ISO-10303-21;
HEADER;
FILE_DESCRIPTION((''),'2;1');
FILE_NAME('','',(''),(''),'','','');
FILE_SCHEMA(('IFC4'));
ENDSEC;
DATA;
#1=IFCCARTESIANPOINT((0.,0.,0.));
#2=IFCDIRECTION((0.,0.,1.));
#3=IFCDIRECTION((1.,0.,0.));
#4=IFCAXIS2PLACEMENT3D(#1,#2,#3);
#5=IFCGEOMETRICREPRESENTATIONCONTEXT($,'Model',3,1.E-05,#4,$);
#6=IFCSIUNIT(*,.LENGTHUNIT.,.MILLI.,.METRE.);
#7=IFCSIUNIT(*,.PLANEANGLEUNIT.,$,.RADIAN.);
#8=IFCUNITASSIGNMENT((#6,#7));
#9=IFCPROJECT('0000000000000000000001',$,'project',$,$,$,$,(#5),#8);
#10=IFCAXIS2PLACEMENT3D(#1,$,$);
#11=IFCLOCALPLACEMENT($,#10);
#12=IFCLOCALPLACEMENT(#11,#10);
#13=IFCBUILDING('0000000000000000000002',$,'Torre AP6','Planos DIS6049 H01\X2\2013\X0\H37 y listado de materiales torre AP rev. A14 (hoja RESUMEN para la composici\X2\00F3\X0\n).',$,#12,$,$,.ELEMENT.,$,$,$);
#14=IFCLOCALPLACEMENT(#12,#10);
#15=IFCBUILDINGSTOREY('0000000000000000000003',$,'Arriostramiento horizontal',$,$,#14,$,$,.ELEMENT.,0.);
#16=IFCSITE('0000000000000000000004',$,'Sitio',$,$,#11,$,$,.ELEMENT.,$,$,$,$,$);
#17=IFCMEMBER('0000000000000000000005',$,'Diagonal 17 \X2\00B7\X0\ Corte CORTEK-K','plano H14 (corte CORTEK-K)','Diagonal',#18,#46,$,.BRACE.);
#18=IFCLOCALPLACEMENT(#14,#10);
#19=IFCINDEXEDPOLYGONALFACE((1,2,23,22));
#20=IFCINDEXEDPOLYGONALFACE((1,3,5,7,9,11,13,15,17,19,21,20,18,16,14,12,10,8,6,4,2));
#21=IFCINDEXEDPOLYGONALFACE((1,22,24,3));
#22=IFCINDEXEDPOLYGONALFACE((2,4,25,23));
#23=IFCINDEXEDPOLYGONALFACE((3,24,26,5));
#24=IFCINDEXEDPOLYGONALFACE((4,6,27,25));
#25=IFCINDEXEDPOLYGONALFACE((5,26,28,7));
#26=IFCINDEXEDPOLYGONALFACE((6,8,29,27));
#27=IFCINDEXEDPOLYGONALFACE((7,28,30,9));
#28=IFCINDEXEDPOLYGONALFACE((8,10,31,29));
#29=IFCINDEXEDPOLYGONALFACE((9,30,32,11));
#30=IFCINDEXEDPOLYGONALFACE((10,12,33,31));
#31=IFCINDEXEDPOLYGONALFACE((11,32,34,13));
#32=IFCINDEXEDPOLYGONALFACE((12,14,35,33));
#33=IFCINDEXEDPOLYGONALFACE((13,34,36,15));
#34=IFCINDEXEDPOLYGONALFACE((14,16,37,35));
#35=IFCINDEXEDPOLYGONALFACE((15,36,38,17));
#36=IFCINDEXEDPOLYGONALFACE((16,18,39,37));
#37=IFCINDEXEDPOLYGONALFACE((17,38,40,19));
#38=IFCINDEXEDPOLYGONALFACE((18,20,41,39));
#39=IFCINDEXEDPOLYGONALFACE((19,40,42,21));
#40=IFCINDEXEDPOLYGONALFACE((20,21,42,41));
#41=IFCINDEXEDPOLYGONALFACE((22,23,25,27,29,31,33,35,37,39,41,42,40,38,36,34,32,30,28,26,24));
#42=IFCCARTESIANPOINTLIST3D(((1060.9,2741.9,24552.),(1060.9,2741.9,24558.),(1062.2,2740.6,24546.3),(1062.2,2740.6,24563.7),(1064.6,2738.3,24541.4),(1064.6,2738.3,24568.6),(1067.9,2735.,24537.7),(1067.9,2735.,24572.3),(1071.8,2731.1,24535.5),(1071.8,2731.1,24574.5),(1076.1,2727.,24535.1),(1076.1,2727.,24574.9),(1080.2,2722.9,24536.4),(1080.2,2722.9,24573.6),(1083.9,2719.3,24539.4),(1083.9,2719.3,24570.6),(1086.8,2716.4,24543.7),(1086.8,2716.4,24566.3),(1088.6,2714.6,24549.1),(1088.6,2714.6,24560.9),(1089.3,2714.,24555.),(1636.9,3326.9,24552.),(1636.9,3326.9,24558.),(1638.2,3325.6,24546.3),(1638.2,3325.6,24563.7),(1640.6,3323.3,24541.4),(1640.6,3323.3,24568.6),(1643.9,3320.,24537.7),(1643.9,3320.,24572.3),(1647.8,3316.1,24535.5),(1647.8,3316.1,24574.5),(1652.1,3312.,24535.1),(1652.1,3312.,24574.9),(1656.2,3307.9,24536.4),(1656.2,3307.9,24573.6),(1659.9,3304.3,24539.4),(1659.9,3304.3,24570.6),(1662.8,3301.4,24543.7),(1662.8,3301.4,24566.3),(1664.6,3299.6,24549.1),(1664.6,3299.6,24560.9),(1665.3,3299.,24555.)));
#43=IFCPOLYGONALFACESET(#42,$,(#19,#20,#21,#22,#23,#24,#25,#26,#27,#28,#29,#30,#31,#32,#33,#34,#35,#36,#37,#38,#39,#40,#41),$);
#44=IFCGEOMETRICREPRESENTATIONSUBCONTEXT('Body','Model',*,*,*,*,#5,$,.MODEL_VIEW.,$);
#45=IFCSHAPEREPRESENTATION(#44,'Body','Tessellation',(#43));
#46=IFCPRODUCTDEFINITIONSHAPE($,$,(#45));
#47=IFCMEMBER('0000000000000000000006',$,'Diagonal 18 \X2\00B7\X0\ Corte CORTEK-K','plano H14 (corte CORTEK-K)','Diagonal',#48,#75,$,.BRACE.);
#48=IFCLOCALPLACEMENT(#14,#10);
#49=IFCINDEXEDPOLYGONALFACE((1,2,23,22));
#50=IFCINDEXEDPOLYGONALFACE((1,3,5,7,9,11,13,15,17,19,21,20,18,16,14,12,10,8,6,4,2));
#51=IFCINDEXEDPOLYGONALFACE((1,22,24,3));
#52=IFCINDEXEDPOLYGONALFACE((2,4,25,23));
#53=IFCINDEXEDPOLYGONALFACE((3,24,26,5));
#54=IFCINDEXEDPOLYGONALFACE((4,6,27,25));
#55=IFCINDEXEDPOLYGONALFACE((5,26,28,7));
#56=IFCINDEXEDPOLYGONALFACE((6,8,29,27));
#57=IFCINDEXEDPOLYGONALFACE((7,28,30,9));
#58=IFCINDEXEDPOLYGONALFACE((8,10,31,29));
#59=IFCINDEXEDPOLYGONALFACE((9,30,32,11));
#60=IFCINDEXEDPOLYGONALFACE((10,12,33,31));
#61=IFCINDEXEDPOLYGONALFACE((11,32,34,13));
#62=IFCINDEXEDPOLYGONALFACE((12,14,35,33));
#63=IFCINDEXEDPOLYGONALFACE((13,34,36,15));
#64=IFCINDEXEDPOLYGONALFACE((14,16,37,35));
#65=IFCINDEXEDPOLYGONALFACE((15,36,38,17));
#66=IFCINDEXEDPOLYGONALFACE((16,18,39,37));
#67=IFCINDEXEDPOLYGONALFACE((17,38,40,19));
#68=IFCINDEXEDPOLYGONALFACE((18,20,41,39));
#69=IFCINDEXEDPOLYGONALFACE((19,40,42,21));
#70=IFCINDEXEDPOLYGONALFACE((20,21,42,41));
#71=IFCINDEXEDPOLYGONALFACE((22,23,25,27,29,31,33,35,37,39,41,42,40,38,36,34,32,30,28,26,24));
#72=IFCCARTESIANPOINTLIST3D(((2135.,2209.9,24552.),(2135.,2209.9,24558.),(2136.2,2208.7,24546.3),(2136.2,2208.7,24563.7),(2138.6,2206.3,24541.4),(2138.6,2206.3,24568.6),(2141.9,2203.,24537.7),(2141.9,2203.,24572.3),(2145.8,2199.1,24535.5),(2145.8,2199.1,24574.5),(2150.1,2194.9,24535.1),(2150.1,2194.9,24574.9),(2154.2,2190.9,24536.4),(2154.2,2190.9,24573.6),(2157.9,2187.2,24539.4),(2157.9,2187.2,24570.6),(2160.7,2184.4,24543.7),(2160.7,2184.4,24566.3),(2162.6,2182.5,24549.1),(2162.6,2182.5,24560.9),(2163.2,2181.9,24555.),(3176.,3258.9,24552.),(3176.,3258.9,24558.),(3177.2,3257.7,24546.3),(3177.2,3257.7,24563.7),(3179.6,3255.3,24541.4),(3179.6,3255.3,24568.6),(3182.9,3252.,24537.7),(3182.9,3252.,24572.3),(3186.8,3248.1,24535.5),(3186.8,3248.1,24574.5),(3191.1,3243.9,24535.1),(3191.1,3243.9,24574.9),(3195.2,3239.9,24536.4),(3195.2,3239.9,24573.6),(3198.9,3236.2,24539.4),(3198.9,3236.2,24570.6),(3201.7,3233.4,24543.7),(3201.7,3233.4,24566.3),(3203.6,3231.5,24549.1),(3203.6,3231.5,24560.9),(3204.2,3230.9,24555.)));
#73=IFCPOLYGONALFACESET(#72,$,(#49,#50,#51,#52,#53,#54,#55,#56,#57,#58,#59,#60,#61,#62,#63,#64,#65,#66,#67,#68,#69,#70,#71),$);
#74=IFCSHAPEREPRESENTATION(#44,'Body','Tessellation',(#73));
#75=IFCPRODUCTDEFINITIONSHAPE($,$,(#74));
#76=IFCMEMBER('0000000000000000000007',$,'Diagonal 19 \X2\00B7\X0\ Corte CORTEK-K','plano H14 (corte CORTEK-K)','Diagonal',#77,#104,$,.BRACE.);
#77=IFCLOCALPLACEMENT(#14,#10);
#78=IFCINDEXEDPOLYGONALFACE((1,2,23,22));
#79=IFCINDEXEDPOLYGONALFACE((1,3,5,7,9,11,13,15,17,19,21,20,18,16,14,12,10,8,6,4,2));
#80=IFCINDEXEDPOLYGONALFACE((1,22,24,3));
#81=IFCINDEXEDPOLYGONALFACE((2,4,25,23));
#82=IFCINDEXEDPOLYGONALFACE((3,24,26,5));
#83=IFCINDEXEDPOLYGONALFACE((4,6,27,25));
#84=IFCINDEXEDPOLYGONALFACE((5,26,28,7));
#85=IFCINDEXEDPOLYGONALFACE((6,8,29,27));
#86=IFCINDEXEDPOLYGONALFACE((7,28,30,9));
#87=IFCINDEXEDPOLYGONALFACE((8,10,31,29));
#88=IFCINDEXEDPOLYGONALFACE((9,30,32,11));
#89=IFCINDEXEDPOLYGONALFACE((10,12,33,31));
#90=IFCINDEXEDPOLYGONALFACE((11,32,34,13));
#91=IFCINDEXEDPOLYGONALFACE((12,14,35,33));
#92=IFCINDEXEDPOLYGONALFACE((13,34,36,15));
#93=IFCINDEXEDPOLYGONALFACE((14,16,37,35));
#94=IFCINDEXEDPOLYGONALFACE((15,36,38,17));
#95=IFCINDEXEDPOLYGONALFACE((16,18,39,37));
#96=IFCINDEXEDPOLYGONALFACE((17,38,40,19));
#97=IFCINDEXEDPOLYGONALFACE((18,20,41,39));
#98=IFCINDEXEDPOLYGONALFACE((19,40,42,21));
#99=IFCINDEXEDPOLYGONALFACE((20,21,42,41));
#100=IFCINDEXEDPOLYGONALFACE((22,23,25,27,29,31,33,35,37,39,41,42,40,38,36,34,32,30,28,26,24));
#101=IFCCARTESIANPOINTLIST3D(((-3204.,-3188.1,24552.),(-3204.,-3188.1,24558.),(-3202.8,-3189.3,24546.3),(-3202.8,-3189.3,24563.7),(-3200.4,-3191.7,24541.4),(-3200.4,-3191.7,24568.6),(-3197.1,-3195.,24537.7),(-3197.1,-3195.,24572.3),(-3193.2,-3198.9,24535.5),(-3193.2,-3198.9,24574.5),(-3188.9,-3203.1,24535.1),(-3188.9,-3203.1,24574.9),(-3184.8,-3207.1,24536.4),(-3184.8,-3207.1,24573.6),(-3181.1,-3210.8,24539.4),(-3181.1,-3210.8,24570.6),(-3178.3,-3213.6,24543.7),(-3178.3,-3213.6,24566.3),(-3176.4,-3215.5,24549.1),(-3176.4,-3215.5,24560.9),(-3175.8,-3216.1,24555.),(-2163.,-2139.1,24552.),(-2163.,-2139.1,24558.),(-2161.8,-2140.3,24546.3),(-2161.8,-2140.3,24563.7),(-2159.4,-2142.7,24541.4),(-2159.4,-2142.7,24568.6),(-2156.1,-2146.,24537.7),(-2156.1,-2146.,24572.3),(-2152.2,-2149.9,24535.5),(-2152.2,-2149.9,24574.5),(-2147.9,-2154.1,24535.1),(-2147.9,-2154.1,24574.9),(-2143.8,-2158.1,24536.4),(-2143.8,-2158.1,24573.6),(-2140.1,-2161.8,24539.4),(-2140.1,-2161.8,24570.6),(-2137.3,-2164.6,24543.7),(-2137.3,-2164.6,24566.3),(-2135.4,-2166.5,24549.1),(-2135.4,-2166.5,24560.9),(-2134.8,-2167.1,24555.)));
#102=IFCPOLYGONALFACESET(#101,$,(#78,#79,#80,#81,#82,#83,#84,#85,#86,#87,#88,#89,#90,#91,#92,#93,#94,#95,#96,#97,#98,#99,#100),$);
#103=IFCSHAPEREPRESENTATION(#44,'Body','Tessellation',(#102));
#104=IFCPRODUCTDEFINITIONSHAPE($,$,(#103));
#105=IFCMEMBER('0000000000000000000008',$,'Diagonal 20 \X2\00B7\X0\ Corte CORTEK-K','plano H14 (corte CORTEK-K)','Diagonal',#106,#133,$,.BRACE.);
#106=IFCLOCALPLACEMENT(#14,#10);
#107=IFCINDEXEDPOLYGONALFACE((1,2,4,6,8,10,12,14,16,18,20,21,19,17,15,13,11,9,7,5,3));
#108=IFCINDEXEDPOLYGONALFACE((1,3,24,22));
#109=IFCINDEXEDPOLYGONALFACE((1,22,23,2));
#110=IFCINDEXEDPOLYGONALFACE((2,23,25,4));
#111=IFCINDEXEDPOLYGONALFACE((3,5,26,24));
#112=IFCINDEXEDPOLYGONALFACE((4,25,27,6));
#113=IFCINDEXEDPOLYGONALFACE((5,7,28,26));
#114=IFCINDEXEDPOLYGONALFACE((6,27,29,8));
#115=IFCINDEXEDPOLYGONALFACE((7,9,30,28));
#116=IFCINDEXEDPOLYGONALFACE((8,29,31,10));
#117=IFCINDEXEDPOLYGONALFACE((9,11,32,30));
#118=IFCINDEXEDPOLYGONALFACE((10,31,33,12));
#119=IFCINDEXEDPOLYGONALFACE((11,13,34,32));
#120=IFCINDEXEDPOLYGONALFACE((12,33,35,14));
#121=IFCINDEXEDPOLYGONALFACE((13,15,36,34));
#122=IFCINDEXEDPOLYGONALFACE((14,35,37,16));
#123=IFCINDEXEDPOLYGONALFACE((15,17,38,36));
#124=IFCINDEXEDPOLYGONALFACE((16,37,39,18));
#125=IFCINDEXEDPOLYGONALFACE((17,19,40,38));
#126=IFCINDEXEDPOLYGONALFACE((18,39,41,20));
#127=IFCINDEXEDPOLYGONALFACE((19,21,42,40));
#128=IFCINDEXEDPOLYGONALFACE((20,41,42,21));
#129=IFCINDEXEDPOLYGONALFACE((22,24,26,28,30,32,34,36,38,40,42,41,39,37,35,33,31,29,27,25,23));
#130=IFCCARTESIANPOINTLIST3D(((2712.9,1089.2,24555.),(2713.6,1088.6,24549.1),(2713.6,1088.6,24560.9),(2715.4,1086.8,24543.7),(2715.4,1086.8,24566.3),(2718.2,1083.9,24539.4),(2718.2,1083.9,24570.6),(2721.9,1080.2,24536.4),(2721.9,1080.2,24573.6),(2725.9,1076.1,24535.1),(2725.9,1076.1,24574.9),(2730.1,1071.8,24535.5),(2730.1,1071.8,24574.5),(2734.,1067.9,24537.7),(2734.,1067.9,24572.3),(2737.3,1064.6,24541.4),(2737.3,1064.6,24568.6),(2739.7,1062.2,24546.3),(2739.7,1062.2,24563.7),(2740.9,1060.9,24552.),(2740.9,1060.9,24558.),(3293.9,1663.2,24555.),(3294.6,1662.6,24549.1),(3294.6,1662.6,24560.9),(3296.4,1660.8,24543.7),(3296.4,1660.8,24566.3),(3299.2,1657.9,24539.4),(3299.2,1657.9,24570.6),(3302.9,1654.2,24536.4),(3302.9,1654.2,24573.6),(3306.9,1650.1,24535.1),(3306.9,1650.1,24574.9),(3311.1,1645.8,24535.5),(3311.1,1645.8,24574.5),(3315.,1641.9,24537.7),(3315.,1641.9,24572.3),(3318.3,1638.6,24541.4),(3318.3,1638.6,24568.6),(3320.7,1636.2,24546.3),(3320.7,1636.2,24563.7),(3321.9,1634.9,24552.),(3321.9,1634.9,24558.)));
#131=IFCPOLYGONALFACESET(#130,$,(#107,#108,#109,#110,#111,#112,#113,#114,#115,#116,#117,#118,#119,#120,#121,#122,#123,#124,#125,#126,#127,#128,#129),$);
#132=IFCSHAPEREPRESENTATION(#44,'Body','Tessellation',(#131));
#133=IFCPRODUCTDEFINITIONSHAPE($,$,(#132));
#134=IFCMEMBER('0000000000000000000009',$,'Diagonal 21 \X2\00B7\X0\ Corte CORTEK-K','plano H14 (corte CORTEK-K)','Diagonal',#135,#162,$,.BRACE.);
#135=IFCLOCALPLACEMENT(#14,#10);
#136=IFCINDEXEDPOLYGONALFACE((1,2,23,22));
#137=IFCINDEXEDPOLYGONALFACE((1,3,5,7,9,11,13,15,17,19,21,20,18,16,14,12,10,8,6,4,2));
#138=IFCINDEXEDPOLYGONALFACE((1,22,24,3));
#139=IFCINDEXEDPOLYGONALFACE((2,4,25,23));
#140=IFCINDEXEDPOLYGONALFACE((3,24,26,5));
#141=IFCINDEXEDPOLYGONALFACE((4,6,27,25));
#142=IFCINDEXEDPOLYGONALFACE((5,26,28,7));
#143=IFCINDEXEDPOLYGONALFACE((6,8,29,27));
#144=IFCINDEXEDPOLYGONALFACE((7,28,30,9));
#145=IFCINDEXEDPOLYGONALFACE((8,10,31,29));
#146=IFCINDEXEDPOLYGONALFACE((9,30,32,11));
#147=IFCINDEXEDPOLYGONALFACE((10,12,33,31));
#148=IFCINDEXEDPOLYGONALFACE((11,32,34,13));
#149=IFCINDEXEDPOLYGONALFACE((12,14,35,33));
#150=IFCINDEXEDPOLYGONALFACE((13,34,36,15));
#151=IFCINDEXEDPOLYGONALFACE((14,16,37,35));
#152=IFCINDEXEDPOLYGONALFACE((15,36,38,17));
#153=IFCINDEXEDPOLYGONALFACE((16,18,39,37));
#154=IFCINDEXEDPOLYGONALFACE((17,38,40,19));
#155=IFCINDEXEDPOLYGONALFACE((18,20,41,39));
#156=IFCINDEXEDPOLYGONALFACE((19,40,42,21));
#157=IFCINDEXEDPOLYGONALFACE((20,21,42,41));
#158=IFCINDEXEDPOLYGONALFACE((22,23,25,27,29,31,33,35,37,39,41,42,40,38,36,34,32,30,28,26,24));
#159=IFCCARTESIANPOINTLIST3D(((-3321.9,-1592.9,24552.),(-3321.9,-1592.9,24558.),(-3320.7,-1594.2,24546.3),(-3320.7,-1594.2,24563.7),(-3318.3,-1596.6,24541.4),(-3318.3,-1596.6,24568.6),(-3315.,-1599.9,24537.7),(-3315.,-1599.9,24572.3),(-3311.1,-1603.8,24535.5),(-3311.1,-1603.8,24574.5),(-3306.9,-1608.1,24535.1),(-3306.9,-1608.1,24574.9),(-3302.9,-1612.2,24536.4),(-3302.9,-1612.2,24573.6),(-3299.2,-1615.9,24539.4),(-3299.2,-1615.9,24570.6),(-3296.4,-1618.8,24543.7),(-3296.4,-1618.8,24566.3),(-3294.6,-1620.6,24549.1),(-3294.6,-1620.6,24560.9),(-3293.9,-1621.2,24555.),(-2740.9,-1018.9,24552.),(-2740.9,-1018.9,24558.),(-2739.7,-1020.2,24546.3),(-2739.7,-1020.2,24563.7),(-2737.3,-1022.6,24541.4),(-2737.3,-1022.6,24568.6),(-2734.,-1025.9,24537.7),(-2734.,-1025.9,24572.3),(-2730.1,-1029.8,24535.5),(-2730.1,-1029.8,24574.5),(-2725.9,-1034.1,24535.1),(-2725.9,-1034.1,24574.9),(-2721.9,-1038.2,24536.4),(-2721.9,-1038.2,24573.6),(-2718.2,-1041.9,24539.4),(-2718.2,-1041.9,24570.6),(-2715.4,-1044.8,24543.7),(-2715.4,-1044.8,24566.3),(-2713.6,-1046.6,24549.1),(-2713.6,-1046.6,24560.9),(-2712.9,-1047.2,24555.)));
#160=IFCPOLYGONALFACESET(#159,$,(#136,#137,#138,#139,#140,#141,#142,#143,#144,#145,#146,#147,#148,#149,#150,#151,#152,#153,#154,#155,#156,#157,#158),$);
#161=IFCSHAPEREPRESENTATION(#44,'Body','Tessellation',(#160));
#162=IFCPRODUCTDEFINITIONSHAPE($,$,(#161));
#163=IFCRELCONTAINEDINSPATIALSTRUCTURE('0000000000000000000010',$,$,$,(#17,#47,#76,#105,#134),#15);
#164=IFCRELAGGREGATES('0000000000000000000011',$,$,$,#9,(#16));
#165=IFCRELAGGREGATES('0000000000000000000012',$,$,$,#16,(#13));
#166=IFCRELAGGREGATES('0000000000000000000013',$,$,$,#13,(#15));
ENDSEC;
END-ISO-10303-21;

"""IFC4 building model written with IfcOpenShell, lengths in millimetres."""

from ifc_helpers import new_model, si_unit, frame, origin, origin_with_axes, place, context, subcontext, project, spatial, circle, extrude, element, save


model = new_model("IFC4")

# Units and contexts
model_context = context("Model", 3, precision=1e-05, world=origin_with_axes())
body_context = subcontext(model_context, "Body", "Model", "MODEL_VIEW")
ifc_project = project(units=[si_unit("LENGTHUNIT", "METRE", prefix="MILLI"), si_unit("PLANEANGLEUNIT", "RADIAN")], contexts=[model_context])

# Site, building, storey
site_placement = place(None, origin())
site = spatial("IfcSite", under=ifc_project, at=site_placement, Name="Sitio", CompositionType="ELEMENT")
building_placement = place(site_placement, origin())
building = spatial("IfcBuilding", under=site, at=building_placement, Name="Torre AP6", Description="Planos DIS6049 H01–H37 y listado de materiales torre AP rev. A14 (hoja RESUMEN para la composición).", CompositionType="ELEMENT")
storey_placement = place(building_placement, origin())
storey = spatial("IfcBuildingStorey", under=building, at=storey_placement, Name="Arriostramiento horizontal", CompositionType="ELEMENT", Elevation=0.0)

# Members
member_1_placement = place(storey_placement, frame((1651.0, 3313.0, 24555.0), z_axis=(-0.701604, -0.712567, 0.0), x_axis=(0.712567, -0.701604, 0.0)))
element("IfcMember", 1, at=member_1_placement, inside=storey, Name="Diagonal 17 · Corte CORTEK-K", Description="plano H14 (corte CORTEK-K)", ObjectType="Diagonal", PredefinedType="BRACE", context=body_context, shape_type="SweptSolid", body=[
    extrude(circle(Radius=20.0), None, (0.0, 0.0, 1.0), 821.0),
])
for number, where, z_axis, x_axis, name in (
    (2, (3190.0, 3245.0, 24555.0), (-0.704395, -0.709808, 0.0), (0.709808, -0.704395, 0.0), "Diagonal 18 · Corte CORTEK-K"),
    (3, (-2149.0, -2153.0, 24555.0), (-0.704395, -0.709808, 0.0), (0.709808, -0.704395, 0.0), "Diagonal 19 · Corte CORTEK-K"),
):
    element("IfcMember", number, at=place(storey_placement, frame(where, z_axis=z_axis, x_axis=x_axis)), inside=storey, Name=name, Description="plano H14 (corte CORTEK-K)", ObjectType="Diagonal", PredefinedType="BRACE", context=body_context, shape_type="SweptSolid", body=[
        extrude(circle(Radius=20.0), None, (0.0, 0.0, 1.0), 1477.9),
    ])
for number, where, z_axis, x_axis, name in (
    (4, (3308.0, 1649.0, 24555.0), (-0.711379, -0.702808, 0.0), (-0.702808, 0.711379, 0.0), "Diagonal 20 · Corte CORTEK-K"),
    (5, (-2727.0, -1033.0, 24555.0), (-0.711379, -0.702808, 0.0), (0.702808, -0.711379, 0.0), "Diagonal 21 · Corte CORTEK-K"),
):
    element("IfcMember", number, at=place(storey_placement, frame(where, z_axis=z_axis, x_axis=x_axis)), inside=storey, Name=name, Description="plano H14 (corte CORTEK-K)", ObjectType="Diagonal", PredefinedType="BRACE", context=body_context, shape_type="SweptSolid", body=[
        extrude(circle(Radius=20.0), None, (0.0, 0.0, 1.0), 816.7),
    ])

save(model, "model.ifc")
